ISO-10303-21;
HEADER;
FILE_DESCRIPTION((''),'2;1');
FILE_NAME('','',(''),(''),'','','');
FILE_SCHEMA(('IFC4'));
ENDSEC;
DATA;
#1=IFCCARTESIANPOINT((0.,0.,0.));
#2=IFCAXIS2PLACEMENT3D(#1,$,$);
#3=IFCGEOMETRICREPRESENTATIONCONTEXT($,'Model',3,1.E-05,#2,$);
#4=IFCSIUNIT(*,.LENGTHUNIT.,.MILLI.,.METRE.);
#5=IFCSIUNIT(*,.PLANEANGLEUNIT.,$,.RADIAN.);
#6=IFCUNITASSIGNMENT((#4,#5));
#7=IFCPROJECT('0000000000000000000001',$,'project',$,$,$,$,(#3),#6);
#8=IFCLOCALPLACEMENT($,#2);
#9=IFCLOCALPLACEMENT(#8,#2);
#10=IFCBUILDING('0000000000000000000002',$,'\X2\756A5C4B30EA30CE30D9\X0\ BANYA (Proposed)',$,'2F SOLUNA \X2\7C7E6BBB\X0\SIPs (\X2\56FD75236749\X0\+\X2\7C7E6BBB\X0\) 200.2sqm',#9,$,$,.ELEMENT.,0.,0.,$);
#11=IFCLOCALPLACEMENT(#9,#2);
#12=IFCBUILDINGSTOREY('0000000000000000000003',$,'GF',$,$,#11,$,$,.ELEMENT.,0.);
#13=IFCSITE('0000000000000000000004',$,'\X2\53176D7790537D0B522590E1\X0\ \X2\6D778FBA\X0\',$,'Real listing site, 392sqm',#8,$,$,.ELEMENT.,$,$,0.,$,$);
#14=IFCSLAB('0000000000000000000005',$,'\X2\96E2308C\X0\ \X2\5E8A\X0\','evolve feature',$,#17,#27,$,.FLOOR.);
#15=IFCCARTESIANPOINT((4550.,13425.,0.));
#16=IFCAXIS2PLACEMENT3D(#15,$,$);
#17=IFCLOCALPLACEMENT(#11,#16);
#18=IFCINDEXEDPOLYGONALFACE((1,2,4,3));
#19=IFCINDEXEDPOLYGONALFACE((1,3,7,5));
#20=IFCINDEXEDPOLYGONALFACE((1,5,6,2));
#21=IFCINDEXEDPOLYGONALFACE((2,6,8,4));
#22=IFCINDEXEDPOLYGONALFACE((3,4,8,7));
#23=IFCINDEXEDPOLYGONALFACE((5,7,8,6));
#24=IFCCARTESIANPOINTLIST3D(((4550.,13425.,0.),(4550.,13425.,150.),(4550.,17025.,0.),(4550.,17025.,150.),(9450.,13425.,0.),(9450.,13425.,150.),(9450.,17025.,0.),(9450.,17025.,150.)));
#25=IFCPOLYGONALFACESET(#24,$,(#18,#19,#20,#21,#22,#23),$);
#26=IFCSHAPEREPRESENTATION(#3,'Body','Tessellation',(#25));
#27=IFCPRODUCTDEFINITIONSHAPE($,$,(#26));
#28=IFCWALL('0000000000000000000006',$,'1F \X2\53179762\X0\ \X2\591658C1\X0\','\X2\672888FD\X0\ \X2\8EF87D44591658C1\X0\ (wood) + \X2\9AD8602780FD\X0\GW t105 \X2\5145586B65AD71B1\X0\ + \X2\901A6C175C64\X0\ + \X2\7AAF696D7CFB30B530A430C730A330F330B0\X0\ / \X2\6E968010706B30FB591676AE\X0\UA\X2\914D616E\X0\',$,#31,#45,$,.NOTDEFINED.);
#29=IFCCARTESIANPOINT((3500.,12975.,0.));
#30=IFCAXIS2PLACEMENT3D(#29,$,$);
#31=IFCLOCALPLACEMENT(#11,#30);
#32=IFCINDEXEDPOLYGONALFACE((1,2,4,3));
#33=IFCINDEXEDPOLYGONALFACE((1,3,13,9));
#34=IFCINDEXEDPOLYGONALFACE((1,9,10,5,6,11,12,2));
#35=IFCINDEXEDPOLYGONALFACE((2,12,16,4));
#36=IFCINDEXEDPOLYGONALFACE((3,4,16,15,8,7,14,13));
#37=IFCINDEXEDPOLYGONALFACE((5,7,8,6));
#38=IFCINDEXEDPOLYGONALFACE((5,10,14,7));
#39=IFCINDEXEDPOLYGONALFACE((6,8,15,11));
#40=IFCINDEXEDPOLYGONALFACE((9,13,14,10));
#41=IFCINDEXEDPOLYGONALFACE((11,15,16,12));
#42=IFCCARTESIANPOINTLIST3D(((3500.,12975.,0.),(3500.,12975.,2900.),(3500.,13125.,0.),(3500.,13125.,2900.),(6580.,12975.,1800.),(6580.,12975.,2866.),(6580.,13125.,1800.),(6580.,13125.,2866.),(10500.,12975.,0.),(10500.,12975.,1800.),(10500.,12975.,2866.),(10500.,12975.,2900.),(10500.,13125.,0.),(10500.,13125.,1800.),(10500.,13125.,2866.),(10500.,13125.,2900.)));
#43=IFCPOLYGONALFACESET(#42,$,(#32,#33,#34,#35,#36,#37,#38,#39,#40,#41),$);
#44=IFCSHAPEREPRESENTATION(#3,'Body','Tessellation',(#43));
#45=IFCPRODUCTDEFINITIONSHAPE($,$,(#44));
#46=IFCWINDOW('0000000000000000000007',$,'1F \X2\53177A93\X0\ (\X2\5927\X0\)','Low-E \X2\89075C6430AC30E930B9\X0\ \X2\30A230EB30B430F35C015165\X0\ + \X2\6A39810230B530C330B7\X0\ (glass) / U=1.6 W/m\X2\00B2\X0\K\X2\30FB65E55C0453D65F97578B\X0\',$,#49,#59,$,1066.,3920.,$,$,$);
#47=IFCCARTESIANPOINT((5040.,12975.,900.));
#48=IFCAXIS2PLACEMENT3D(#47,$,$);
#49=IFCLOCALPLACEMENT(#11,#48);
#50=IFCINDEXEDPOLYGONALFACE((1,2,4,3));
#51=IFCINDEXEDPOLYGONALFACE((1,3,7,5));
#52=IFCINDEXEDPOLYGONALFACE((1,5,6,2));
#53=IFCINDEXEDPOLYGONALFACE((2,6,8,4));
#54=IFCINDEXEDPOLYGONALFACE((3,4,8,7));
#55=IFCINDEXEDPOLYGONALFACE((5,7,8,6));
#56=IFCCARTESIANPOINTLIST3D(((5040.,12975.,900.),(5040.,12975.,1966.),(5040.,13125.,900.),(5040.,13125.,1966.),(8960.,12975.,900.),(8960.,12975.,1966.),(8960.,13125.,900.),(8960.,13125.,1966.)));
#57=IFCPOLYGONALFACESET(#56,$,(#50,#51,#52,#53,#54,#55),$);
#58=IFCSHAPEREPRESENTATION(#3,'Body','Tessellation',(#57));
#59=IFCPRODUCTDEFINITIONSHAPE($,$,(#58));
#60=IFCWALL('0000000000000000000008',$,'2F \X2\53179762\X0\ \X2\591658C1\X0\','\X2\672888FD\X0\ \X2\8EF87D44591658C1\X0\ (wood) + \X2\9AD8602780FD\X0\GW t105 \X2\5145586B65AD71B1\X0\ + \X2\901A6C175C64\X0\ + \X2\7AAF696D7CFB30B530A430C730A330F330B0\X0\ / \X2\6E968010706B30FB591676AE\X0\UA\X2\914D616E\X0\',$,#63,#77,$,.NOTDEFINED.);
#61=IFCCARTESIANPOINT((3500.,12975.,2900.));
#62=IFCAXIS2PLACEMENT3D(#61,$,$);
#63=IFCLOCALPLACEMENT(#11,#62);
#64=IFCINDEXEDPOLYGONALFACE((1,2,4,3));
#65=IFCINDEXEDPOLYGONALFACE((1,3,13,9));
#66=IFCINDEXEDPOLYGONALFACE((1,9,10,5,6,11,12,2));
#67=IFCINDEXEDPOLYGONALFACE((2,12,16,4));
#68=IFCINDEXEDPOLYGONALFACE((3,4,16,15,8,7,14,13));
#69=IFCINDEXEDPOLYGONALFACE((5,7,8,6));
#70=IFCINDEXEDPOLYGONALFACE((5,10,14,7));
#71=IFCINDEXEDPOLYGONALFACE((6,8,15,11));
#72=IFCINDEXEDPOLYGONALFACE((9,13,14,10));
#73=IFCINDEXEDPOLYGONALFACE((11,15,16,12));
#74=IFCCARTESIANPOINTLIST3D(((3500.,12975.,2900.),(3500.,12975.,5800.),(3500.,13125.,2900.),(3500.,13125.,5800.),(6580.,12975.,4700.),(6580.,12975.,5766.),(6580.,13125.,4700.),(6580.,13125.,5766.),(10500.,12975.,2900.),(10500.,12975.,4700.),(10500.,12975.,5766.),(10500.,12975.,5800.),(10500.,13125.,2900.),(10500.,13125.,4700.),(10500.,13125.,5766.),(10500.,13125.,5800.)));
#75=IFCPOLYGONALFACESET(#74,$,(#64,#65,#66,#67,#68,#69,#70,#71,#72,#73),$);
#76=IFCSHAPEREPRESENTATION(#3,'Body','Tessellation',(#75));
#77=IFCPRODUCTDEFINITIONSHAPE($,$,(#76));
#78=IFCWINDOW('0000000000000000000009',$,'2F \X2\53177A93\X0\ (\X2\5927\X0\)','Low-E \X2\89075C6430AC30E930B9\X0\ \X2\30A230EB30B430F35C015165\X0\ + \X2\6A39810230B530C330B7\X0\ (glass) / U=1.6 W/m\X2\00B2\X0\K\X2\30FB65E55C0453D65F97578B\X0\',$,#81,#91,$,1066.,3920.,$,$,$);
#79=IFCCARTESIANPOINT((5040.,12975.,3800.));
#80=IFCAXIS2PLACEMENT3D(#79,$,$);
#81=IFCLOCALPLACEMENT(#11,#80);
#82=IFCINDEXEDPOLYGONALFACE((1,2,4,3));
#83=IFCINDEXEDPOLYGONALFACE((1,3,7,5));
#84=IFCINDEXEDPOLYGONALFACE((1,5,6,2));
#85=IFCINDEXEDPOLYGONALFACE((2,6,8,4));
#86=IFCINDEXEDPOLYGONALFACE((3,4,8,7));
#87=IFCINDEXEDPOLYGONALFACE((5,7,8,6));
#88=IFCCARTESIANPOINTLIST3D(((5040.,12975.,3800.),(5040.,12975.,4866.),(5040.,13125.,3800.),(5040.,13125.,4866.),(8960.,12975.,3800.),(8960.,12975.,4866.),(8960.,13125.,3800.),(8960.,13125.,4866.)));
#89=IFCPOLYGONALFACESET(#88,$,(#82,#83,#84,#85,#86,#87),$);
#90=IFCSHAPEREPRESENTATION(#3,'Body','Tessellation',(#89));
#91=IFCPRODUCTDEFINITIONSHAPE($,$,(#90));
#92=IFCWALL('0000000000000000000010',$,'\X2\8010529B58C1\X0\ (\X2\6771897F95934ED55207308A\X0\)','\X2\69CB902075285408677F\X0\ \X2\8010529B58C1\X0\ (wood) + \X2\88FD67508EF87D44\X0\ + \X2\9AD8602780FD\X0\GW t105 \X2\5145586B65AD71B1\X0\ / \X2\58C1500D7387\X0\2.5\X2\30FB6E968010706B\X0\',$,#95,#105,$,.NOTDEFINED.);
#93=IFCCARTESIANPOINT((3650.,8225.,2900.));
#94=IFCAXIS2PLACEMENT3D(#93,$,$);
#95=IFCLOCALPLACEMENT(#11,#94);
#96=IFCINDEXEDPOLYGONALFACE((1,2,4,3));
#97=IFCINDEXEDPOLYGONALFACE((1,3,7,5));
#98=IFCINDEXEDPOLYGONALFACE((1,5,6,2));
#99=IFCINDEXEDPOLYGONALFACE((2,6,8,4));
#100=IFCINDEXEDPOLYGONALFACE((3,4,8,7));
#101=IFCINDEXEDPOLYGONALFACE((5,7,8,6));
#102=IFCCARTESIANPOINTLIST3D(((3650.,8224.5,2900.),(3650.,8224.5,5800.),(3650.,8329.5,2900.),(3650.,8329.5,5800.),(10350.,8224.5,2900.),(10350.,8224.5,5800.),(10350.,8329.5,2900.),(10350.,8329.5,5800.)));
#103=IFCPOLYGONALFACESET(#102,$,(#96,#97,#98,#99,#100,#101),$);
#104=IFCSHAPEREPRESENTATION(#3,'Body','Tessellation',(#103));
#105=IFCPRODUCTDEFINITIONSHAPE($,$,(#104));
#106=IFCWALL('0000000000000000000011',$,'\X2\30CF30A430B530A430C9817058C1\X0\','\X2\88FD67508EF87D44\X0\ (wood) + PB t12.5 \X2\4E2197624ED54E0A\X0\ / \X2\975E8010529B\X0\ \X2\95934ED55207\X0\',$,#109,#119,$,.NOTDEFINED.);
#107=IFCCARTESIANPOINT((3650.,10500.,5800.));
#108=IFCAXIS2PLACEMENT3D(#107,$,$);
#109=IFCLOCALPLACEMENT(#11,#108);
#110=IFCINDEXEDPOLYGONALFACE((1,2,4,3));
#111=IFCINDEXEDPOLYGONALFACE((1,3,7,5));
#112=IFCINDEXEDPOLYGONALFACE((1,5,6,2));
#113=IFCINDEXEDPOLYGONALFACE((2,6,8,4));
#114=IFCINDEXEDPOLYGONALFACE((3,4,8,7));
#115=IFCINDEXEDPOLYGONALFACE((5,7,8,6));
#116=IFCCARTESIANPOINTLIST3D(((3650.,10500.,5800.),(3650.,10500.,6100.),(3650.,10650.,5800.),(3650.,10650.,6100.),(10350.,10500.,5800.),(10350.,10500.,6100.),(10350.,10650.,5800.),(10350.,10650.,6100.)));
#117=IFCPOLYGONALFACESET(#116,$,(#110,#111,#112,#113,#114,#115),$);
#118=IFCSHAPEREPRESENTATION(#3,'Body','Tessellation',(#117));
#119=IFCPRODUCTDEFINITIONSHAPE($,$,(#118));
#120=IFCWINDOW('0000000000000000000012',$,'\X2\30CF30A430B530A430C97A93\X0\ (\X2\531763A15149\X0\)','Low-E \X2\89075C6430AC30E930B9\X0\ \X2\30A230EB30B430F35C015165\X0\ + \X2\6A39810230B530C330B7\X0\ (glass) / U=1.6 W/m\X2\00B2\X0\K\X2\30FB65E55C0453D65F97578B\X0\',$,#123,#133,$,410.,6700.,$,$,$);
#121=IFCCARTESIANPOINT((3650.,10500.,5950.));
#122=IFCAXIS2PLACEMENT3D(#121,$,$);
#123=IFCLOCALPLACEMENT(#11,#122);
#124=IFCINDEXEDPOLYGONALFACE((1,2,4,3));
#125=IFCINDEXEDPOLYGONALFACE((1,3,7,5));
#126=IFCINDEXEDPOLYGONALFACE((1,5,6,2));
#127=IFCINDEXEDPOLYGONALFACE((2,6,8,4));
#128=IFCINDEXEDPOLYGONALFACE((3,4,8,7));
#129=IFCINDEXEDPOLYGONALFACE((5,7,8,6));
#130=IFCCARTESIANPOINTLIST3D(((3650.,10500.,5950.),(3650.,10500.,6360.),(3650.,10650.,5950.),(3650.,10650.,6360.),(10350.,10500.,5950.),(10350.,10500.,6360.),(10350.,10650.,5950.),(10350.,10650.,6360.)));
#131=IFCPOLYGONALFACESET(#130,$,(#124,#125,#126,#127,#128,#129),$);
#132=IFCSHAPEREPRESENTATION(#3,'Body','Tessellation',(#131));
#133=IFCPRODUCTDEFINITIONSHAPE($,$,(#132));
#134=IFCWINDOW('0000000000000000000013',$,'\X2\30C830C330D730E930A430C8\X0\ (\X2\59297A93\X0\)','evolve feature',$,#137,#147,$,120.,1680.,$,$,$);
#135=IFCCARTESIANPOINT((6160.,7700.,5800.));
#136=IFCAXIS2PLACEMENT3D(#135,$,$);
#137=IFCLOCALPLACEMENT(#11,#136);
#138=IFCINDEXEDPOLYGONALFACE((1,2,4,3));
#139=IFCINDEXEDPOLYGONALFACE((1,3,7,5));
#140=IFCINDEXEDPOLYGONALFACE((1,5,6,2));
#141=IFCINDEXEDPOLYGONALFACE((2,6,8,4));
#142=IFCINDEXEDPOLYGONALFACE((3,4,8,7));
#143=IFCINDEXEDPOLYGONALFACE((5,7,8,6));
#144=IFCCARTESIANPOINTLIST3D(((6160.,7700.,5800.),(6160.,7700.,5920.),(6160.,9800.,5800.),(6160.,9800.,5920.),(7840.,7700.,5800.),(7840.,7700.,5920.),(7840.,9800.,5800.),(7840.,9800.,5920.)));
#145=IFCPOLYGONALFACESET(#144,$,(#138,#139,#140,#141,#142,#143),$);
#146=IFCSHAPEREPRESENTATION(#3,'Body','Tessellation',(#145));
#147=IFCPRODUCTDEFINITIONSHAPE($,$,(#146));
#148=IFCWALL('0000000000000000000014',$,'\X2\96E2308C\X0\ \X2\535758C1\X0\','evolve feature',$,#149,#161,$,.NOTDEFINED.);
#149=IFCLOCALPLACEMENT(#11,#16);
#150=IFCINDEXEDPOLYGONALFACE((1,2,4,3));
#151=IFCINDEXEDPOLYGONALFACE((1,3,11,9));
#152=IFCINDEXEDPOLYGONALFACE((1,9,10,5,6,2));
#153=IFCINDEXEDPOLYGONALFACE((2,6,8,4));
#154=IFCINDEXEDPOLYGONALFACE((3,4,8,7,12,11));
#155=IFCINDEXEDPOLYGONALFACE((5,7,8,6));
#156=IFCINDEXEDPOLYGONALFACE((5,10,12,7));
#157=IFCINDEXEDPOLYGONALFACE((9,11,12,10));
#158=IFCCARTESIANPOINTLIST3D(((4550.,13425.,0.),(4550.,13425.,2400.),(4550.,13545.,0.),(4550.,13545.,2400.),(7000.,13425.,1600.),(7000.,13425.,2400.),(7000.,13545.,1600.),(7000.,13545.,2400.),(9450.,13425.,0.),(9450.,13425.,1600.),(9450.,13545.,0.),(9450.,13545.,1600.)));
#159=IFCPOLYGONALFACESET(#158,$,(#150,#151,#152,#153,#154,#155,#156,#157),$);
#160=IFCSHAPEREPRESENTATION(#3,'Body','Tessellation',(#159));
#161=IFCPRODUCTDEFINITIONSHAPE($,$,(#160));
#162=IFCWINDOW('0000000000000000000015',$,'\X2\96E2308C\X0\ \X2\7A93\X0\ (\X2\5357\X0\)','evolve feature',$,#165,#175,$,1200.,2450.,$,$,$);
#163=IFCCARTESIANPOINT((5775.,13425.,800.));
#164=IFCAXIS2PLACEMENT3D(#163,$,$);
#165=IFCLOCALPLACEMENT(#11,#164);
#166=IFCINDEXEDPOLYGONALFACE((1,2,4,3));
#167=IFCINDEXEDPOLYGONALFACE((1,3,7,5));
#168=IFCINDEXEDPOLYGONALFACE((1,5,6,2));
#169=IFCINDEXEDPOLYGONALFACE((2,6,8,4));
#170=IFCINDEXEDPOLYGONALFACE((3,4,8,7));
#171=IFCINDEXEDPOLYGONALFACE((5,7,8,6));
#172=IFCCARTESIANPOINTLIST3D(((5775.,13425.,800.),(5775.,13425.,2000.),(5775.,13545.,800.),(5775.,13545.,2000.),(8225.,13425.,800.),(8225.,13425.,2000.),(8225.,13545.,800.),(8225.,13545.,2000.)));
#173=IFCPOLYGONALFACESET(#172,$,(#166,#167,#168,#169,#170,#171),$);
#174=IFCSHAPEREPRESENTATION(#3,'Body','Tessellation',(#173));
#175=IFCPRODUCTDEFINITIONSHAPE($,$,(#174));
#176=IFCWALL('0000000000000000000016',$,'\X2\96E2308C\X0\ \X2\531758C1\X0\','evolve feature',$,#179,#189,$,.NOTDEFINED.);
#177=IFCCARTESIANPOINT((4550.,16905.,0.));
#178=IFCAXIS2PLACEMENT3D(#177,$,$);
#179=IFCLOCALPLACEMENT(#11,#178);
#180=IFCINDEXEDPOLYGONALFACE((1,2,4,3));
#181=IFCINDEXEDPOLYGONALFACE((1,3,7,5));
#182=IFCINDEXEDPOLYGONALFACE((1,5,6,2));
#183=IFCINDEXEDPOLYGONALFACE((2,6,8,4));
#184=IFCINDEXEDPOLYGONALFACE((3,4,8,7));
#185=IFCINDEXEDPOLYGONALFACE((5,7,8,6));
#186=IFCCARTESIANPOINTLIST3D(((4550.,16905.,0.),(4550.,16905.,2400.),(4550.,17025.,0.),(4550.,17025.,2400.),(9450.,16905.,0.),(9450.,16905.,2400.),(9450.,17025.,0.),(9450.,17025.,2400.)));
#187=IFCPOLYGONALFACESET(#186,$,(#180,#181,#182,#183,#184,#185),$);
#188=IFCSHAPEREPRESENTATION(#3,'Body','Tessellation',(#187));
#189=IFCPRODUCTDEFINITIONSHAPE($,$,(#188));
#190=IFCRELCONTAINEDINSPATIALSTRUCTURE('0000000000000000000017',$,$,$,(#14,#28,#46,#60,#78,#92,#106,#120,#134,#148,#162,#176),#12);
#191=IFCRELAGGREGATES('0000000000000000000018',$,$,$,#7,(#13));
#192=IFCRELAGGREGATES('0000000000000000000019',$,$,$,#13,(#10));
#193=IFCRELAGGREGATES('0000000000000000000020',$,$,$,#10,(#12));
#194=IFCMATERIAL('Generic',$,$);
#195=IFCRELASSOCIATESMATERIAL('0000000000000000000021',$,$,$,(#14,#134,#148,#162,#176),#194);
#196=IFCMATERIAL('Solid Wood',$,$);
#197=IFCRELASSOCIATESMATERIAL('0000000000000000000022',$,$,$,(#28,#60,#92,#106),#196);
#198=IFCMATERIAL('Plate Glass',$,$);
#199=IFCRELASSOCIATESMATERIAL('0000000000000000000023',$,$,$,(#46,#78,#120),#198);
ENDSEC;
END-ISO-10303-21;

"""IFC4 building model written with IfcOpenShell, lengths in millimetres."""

from ifc_helpers import new_model, si_unit, frame, frame_2d, origin, place, context, project, spatial, rectangle, extrude, material, element, fill, save


model = new_model("IFC4")

# Units and contexts
model_context = context("Model", 3, precision=1e-05, world=origin())
ifc_project = project(units=[si_unit("LENGTHUNIT", "METRE", prefix="MILLI"), si_unit("PLANEANGLEUNIT", "RADIAN")], contexts=[model_context])

# Site, building, storey
site_placement = place(None, origin())
site = spatial("IfcSite", under=ifc_project, at=site_placement, Name="北海道紋別郡 海辺", ObjectType="Real listing site, 392sqm", CompositionType="ELEMENT", RefElevation=0.0)
building_placement = place(site_placement, origin())
building = spatial("IfcBuilding", under=site, at=building_placement, Name="番屋リノベ BANYA (Proposed)", ObjectType="2F SOLUNA 籾殻SIPs (国産杉+籾殻) 200.2sqm", CompositionType="ELEMENT", ElevationOfRefHeight=0.0, ElevationOfTerrain=0.0)
storey_placement = place(building_placement, origin())
storey = spatial("IfcBuildingStorey", under=building, at=storey_placement, Name="GF", CompositionType="ELEMENT", Elevation=0.0)

# Slab
ifc_material_1 = material(Name="Generic")
slab_placement = place(storey_placement, frame((4550.0, 13425.0, 0.0)))
element("IfcSlab", 1, at=slab_placement, inside=storey, material=ifc_material_1, Name="離れ 床", Description="evolve feature", PredefinedType="FLOOR", context=model_context, shape_type="SweptSolid", body=[
    extrude(rectangle(XDim=4900.0, YDim=3600.0, at=frame_2d((2450.0, 1800.0))), frame((4550.0, 13425.0, 0.0)), (0.0, 0.0, 1.0), 150.0),
])

# Wall, opening, window
ifc_material_2 = material(Name="Solid Wood")
wall_1_placement = place(storey_placement, frame((3500.0, 12975.0, 0.0)))
wall_1 = element("IfcWall", 2, at=wall_1_placement, inside=storey, material=ifc_material_2, Name="1F 北面 外壁", Description="木製 軸組外壁 (wood) + 高性能GW t105 充填断熱 + 通気層 + 窯業系サイディング / 準耐火・外皮UA配慮", PredefinedType="NOTDEFINED", context=model_context, shape_type="SweptSolid", body=[
    extrude(rectangle(XDim=7000.0, YDim=150.0, at=frame_2d((3500.0, 75.0))), frame((3500.0, 12975.0, 0.0)), (0.0, 0.0, 1.0), 2900.0),
])
opening_1_placement = place(storey_placement, frame((5040.0, 12975.0, 900.0)))
opening_1 = element("IfcOpeningElement", 3, at=opening_1_placement, cuts=wall_1, PredefinedType="NOTDEFINED", context=model_context, shape_type="SweptSolid", body=[
    extrude(rectangle(XDim=3920.0, YDim=150.0, at=frame_2d((1960.0, 75.0))), frame((5040.0, 12975.0, 900.0)), (0.0, 0.0, 1.0), 1066.0),
])
ifc_material_3 = material(Name="Plate Glass")
window_1_placement = place(storey_placement, frame((5040.0, 12975.0, 900.0)))
window_1 = element("IfcWindow", 4, at=window_1_placement, inside=storey, material=ifc_material_3, Name="1F 北窓 (大)", Description="Low-E 複層ガラス アルゴン封入 + 樹脂サッシ (glass) / U=1.6 W/m²K・日射取得型", OverallHeight=1066.0, OverallWidth=3920.0, context=model_context, shape_type="SweptSolid", body=[
    extrude(rectangle(XDim=3920.0, YDim=150.0, at=frame_2d((1960.0, 75.0))), frame((5040.0, 12975.0, 900.0)), (0.0, 0.0, 1.0), 1066.0),
])
fill(opening_1, window_1)

# Wall, opening, window
wall_2_placement = place(storey_placement, frame((3500.0, 12975.0, 2900.0)))
wall_2 = element("IfcWall", 5, at=wall_2_placement, inside=storey, material=ifc_material_2, Name="2F 北面 外壁", Description="木製 軸組外壁 (wood) + 高性能GW t105 充填断熱 + 通気層 + 窯業系サイディング / 準耐火・外皮UA配慮", PredefinedType="NOTDEFINED", context=model_context, shape_type="SweptSolid", body=[
    extrude(rectangle(XDim=7000.0, YDim=150.0, at=frame_2d((3500.0, 75.0))), frame((3500.0, 12975.0, 2900.0)), (0.0, 0.0, 1.0), 2900.0),
])
opening_2_placement = place(storey_placement, frame((5040.0, 12975.0, 3800.0)))
opening_2 = element("IfcOpeningElement", 6, at=opening_2_placement, cuts=wall_2, PredefinedType="NOTDEFINED", context=model_context, shape_type="SweptSolid", body=[
    extrude(rectangle(XDim=3920.0, YDim=150.0, at=frame_2d((1960.0, 75.0))), frame((5040.0, 12975.0, 3800.0)), (0.0, 0.0, 1.0), 1066.0),
])
window_2_placement = place(storey_placement, frame((5040.0, 12975.0, 3800.0)))
window_2 = element("IfcWindow", 7, at=window_2_placement, inside=storey, material=ifc_material_3, Name="2F 北窓 (大)", Description="Low-E 複層ガラス アルゴン封入 + 樹脂サッシ (glass) / U=1.6 W/m²K・日射取得型", OverallHeight=1066.0, OverallWidth=3920.0, context=model_context, shape_type="SweptSolid", body=[
    extrude(rectangle(XDim=3920.0, YDim=150.0, at=frame_2d((1960.0, 75.0))), frame((5040.0, 12975.0, 3800.0)), (0.0, 0.0, 1.0), 1066.0),
])
fill(opening_2, window_2)

# Wall
wall_3_placement = place(storey_placement, frame((3650.0, 8225.0, 2900.0)))
element("IfcWall", 8, at=wall_3_placement, inside=storey, material=ifc_material_2, Name="耐力壁 (東西間仕切り)", Description="構造用合板 耐力壁 (wood) + 製材軸組 + 高性能GW t105 充填断熱 / 壁倍率2.5・準耐火", PredefinedType="NOTDEFINED", context=model_context, shape_type="SweptSolid", body=[
    extrude(rectangle(XDim=6700.0, YDim=105.0, at=frame_2d((3350.0, 52.0))), frame((3650.0, 8225.0, 2900.0)), (0.0, 0.0, 1.0), 2900.0),
])

# Wall, opening, window
wall_4_placement = place(storey_placement, frame((3650.0, 10500.0, 5800.0)))
wall_4 = element("IfcWall", 9, at=wall_4_placement, inside=storey, material=ifc_material_2, Name="ハイサイド腰壁", Description="製材軸組 (wood) + PB t12.5 両面仕上 / 非耐力 間仕切", PredefinedType="NOTDEFINED", context=model_context, shape_type="SweptSolid", body=[
    extrude(rectangle(XDim=6700.0, YDim=150.0, at=frame_2d((3350.0, 75.0))), frame((3650.0, 10500.0, 5800.0)), (0.0, 0.0, 1.0), 700.0),
])
opening_3_placement = place(storey_placement, frame((3650.0, 10500.0, 5950.0)))
opening_3 = element("IfcOpeningElement", 10, at=opening_3_placement, cuts=wall_4, PredefinedType="NOTDEFINED", context=model_context, shape_type="SweptSolid", body=[
    extrude(rectangle(XDim=6700.0, YDim=150.0, at=frame_2d((3350.0, 75.0))), frame((3650.0, 10500.0, 5950.0)), (0.0, 0.0, 1.0), 410.0),
])
window_3_placement = place(storey_placement, frame((3650.0, 10500.0, 5950.0)))
window_3 = element("IfcWindow", 11, at=window_3_placement, inside=storey, material=ifc_material_3, Name="ハイサイド窓 (北採光)", Description="Low-E 複層ガラス アルゴン封入 + 樹脂サッシ (glass) / U=1.6 W/m²K・日射取得型", OverallHeight=410.0, OverallWidth=6700.0, context=model_context, shape_type="SweptSolid", body=[
    extrude(rectangle(XDim=6700.0, YDim=150.0, at=frame_2d((3350.0, 75.0))), frame((3650.0, 10500.0, 5950.0)), (0.0, 0.0, 1.0), 410.0),
])
fill(opening_3, window_3)

# Window
window_4_placement = place(storey_placement, frame((6160.0, 7700.0, 5800.0)))
element("IfcWindow", 12, at=window_4_placement, inside=storey, material=ifc_material_1, Name="トップライト (天窓)", Description="evolve feature", OverallHeight=120.0, OverallWidth=1680.0, context=model_context, shape_type="SweptSolid", body=[
    extrude(rectangle(XDim=1680.0, YDim=2100.0, at=frame_2d((840.0, 1050.0))), frame((6160.0, 7700.0, 5800.0)), (0.0, 0.0, 1.0), 120.0),
])

# Wall, opening, window
wall_5_placement = place(storey_placement, frame((4550.0, 13425.0, 0.0)))
wall_5 = element("IfcWall", 13, at=wall_5_placement, inside=storey, material=ifc_material_1, Name="離れ 南壁", Description="evolve feature", PredefinedType="NOTDEFINED", context=model_context, shape_type="SweptSolid", body=[
    extrude(rectangle(XDim=4900.0, YDim=120.0, at=frame_2d((2450.0, 60.0))), frame((4550.0, 13425.0, 0.0)), (0.0, 0.0, 1.0), 2400.0),
])
opening_4_placement = place(storey_placement, frame((5775.0, 13425.0, 800.0)))
opening_4 = element("IfcOpeningElement", 14, at=opening_4_placement, cuts=wall_5, PredefinedType="NOTDEFINED", context=model_context, shape_type="SweptSolid", body=[
    extrude(rectangle(XDim=2450.0, YDim=120.0, at=frame_2d((1225.0, 60.0))), frame((5775.0, 13425.0, 800.0)), (0.0, 0.0, 1.0), 1200.0),
])
window_5_placement = place(storey_placement, frame((5775.0, 13425.0, 800.0)))
window_5 = element("IfcWindow", 15, at=window_5_placement, inside=storey, material=ifc_material_1, Name="離れ 窓 (南)", Description="evolve feature", OverallHeight=1200.0, OverallWidth=2450.0, context=model_context, shape_type="SweptSolid", body=[
    extrude(rectangle(XDim=2450.0, YDim=120.0, at=frame_2d((1225.0, 60.0))), frame((5775.0, 13425.0, 800.0)), (0.0, 0.0, 1.0), 1200.0),
])
fill(opening_4, window_5)

# Wall
wall_6_placement = place(storey_placement, frame((4550.0, 16905.0, 0.0)))
element("IfcWall", 16, at=wall_6_placement, inside=storey, material=ifc_material_1, Name="離れ 北壁", Description="evolve feature", PredefinedType="NOTDEFINED", context=model_context, shape_type="SweptSolid", body=[
    extrude(rectangle(XDim=4900.0, YDim=120.0, at=frame_2d((2450.0, 60.0))), frame((4550.0, 16905.0, 0.0)), (0.0, 0.0, 1.0), 2400.0),
])

save(model, "model.ifc")
